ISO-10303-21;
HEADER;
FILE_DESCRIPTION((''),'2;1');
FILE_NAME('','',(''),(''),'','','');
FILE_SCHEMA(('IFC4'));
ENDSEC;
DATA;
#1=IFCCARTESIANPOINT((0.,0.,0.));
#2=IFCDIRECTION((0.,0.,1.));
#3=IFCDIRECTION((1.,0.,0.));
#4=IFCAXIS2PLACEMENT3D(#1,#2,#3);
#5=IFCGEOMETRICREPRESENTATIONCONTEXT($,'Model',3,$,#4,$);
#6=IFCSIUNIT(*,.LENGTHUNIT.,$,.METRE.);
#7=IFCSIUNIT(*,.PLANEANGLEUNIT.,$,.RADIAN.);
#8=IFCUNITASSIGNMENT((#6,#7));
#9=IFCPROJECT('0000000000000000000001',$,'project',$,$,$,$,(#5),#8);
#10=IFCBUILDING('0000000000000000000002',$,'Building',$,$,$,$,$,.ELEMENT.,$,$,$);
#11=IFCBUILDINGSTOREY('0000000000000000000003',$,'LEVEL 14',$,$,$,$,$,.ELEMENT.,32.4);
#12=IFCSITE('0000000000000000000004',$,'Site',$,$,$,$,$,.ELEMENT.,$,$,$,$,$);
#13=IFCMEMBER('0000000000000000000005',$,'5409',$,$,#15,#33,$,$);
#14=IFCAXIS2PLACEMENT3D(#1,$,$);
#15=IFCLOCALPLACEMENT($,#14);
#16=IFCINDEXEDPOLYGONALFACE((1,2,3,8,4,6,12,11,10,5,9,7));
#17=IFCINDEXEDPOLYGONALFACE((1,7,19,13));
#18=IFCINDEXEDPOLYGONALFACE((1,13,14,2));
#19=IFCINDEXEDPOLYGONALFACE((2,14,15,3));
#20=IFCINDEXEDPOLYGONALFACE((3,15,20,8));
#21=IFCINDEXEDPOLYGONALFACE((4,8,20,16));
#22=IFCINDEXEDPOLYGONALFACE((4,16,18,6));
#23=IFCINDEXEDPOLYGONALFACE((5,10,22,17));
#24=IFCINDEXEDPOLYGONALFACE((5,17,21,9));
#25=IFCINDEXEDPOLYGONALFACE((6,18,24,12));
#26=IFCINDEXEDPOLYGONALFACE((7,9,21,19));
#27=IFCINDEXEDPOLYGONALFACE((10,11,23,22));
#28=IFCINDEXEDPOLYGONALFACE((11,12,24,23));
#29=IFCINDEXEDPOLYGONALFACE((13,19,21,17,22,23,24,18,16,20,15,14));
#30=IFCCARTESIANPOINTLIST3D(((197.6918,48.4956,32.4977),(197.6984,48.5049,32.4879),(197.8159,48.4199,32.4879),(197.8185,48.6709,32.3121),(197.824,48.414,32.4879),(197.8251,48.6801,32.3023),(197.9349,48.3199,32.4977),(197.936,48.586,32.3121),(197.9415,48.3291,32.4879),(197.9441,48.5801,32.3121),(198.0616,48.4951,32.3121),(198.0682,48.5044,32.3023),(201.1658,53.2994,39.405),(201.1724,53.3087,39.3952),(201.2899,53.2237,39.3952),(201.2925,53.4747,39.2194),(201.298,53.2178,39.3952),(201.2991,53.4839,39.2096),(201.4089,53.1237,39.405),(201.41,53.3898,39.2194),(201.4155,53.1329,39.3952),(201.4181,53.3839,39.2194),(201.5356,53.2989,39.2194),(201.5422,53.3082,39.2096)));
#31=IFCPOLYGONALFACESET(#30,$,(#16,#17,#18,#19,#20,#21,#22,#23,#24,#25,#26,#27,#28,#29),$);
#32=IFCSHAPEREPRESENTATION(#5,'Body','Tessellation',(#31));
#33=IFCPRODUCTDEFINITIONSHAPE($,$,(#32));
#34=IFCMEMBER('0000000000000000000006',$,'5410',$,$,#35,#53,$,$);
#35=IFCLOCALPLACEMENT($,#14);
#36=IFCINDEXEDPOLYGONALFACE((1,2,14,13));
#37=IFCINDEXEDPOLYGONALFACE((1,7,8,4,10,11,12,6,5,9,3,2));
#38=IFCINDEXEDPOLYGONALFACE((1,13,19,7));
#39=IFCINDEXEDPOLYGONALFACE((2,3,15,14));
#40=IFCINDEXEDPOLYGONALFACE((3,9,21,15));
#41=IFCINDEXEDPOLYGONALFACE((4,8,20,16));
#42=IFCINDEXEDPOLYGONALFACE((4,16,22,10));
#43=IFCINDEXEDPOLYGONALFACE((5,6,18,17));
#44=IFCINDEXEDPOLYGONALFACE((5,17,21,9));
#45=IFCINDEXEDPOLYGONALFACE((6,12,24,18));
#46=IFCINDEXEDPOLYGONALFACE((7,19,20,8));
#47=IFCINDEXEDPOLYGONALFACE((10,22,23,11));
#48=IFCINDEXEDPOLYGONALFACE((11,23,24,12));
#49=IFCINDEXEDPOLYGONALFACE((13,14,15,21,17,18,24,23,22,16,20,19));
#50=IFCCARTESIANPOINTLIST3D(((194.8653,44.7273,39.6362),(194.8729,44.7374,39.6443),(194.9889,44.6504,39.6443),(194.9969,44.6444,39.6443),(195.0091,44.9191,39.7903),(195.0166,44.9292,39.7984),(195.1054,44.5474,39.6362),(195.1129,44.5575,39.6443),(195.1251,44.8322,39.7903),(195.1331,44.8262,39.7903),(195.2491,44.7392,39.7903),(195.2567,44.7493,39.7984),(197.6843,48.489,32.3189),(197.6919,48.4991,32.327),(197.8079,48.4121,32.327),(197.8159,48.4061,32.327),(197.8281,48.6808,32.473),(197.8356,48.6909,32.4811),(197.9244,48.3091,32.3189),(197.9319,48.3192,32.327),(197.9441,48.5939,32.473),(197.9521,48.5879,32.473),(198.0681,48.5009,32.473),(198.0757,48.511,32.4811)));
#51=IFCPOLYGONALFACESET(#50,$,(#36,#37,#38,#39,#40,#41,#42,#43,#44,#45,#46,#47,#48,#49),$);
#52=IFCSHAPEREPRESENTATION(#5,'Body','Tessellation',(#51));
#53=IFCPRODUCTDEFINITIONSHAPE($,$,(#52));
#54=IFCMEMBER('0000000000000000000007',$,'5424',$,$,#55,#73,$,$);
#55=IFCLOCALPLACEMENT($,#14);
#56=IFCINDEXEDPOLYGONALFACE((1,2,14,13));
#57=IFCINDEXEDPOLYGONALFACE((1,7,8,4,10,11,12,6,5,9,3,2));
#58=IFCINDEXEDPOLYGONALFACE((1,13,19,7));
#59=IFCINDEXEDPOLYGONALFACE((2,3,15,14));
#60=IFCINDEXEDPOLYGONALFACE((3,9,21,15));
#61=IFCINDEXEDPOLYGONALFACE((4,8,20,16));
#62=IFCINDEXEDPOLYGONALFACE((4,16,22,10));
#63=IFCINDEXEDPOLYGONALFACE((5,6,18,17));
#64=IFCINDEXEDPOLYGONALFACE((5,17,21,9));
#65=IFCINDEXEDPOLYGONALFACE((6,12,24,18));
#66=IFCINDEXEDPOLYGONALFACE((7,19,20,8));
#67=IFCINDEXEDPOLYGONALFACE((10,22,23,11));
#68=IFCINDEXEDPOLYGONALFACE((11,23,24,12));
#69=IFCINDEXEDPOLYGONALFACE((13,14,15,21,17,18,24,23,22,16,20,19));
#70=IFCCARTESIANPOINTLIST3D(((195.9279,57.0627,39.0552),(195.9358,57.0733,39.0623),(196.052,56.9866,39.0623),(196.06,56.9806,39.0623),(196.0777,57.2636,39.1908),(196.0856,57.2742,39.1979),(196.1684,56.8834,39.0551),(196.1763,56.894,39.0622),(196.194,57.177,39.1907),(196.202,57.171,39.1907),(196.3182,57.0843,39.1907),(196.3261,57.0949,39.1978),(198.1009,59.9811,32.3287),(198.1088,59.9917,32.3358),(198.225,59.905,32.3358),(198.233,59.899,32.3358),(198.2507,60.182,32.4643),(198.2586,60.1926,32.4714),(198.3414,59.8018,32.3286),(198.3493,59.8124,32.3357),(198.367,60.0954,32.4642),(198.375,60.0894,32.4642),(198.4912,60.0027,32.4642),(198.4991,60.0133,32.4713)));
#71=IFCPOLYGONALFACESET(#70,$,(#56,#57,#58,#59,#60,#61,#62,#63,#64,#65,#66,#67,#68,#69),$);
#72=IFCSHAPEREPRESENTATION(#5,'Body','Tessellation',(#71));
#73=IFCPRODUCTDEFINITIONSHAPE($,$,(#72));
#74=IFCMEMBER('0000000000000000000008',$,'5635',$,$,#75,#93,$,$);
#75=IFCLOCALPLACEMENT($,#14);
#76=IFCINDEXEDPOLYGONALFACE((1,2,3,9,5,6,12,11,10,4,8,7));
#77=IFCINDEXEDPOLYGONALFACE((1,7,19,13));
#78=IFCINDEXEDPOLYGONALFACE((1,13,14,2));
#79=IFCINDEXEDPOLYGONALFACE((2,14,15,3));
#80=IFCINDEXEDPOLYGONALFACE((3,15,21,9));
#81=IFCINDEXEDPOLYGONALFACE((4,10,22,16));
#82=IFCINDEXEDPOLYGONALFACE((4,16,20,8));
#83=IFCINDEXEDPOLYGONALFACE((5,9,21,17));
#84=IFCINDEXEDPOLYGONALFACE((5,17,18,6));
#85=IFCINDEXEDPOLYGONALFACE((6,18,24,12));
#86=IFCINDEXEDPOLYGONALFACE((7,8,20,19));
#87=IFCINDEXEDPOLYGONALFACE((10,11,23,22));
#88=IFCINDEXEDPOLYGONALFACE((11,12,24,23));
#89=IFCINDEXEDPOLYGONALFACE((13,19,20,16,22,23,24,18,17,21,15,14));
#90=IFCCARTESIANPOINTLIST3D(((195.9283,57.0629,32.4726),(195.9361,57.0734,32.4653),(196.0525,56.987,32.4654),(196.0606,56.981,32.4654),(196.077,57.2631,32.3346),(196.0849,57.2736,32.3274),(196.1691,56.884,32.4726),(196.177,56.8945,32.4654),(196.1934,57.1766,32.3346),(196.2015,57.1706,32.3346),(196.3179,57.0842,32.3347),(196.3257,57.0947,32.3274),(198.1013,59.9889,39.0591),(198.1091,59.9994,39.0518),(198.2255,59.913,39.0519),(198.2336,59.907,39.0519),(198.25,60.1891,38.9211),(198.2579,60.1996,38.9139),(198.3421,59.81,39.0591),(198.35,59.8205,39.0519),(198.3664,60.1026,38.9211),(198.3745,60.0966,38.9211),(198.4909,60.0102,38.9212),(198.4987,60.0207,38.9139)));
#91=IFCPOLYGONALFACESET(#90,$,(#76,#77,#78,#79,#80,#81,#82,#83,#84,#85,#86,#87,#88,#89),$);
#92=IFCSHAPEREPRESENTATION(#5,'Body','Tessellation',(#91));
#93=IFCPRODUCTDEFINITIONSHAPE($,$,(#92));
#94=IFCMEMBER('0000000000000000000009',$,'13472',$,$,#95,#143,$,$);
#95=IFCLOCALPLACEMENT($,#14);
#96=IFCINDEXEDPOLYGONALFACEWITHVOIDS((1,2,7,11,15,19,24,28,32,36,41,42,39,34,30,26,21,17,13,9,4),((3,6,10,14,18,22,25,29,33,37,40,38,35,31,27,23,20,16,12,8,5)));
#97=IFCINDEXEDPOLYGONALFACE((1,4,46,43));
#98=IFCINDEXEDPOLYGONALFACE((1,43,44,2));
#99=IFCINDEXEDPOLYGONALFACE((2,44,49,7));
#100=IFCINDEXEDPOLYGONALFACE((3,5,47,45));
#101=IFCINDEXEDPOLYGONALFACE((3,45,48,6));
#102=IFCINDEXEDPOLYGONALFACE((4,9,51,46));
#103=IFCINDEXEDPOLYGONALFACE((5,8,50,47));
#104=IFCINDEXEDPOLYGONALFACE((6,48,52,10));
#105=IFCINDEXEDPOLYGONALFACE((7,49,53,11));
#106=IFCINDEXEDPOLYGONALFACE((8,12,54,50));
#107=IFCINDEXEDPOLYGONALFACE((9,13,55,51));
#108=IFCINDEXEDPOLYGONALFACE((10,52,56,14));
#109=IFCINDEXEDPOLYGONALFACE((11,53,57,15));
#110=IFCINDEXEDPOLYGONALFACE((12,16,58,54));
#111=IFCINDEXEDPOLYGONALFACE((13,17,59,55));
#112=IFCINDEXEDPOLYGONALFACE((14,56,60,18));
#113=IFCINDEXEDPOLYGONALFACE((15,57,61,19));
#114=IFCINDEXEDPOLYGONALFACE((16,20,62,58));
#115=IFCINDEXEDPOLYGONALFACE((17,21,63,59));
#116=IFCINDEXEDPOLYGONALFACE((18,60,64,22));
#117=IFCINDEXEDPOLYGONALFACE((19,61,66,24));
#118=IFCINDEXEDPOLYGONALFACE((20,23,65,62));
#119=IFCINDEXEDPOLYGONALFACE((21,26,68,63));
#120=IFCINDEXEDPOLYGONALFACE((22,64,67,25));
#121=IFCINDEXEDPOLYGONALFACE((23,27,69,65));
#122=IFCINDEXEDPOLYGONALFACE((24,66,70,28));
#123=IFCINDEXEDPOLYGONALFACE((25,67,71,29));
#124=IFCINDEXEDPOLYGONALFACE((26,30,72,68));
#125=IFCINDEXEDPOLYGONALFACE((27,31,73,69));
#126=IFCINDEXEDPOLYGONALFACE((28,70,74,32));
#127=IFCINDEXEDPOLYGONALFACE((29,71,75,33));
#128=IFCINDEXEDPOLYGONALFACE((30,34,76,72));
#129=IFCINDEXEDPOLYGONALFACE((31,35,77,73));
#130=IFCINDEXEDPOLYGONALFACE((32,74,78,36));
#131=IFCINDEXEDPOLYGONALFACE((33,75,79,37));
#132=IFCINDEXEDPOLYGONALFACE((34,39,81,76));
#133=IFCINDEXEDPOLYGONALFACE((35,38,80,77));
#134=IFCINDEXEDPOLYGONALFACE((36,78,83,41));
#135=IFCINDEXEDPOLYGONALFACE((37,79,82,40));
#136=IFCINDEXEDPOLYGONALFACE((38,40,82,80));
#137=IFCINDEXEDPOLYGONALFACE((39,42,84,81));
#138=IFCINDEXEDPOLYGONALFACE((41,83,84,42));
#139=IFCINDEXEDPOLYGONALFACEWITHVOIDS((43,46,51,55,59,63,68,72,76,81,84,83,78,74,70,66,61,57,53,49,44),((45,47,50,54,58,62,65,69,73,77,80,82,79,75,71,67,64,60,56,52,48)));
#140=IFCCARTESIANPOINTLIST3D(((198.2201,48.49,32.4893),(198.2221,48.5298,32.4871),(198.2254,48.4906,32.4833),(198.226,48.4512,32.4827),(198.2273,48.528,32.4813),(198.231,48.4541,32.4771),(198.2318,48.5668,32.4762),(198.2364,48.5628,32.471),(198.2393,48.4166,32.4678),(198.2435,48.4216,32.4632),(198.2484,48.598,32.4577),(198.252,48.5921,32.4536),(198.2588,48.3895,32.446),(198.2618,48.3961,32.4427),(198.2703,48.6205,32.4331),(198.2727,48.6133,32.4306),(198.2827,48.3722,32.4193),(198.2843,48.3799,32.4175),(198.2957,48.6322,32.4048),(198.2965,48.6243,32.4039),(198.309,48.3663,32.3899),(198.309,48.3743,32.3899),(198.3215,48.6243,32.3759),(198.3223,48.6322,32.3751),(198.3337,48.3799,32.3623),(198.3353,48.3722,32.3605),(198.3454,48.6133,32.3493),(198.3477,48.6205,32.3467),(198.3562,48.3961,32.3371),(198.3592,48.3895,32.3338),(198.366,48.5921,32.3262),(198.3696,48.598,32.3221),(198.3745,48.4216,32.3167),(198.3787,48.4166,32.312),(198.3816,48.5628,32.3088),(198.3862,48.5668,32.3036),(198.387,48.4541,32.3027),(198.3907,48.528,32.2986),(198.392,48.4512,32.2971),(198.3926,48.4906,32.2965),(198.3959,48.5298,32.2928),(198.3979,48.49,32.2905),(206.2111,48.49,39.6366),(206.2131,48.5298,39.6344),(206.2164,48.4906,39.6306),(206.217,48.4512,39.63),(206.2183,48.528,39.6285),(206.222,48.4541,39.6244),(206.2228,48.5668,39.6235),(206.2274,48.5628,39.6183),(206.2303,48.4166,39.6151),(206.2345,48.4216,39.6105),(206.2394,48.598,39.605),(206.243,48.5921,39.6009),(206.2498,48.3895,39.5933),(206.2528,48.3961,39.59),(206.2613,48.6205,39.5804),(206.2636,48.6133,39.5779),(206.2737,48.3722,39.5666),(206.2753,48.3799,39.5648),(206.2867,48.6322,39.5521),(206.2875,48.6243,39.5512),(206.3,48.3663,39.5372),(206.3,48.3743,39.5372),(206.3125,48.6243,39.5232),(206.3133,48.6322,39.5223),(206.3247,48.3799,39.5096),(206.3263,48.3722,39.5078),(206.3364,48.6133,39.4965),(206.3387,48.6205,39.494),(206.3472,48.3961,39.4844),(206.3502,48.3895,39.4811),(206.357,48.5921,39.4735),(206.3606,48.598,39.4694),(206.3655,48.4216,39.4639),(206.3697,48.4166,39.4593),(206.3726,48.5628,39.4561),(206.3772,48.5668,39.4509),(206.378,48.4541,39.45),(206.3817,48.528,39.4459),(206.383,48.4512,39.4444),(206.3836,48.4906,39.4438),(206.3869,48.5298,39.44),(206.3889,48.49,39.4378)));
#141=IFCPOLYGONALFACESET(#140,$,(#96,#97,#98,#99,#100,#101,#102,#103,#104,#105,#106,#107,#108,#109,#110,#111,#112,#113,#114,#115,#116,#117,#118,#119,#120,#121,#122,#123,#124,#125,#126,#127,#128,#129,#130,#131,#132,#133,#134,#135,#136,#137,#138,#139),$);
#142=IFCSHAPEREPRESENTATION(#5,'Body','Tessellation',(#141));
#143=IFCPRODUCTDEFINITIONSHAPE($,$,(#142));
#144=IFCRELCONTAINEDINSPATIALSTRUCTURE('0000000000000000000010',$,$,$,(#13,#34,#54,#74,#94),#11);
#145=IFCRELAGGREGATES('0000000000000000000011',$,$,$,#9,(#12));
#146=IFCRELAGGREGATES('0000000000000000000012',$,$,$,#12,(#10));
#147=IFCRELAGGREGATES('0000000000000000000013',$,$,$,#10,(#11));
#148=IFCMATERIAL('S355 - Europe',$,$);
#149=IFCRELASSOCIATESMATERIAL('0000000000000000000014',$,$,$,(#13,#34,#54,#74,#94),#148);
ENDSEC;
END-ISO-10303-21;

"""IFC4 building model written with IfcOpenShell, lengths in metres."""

from ifc_helpers import new_model, si_unit, frame, origin_with_axes, origin_2d_with_axis, place, context, project, spatial, hollow_circle, i_section, extrude, material, material_profile, profile_set, profile_usage, element, save


model = new_model("IFC4")

# Units and contexts
model_context = context("Model", 3, world=origin_with_axes())
ifc_project = project(units=[si_unit("LENGTHUNIT", "METRE"), si_unit("PLANEANGLEUNIT", "RADIAN")], contexts=[model_context])

# Site, building, storey
site = spatial("IfcSite", under=ifc_project, Name="Site", CompositionType="ELEMENT")
building = spatial("IfcBuilding", under=site, Name="Building", CompositionType="ELEMENT")
storey = spatial("IfcBuildingStorey", under=building, Name="LEVEL 14", CompositionType="ELEMENT", Elevation=32.4)

# Shared definitions
ifc_material = material(Name="S355 - Europe")

# Members
ifc_material_profile_1 = material_profile(ifc_material, i_section(OverallWidth=0.3, OverallDepth=0.3, WebThickness=0.01, FlangeThickness=0.015, at=origin_2d_with_axis()))
ifc_profile_set_1 = profile_set([ifc_material_profile_1])
ifc_profile_usage_1 = profile_usage(ifc_profile_set_1, cardinal=10)
member_1_placement = place(None, frame((197.88, 48.5, 32.4), z_axis=(0.381652, 0.527744, 0.758833), x_axis=(-0.810441, 0.585821, 0.0)))
element("IfcMember", 1, at=member_1_placement, inside=storey, material=ifc_profile_usage_1, Name="5409", context=model_context, shape_type="SweptSolid", body=[
    extrude(i_section(OverallWidth=0.3, OverallDepth=0.3, WebThickness=0.01, FlangeThickness=0.015, at=origin_2d_with_axis()), origin_with_axes(), (0.0, 0.0, 1.0), 9.1025),
])
ifc_material_profile_2 = material_profile(ifc_material, i_section(OverallWidth=0.3, OverallDepth=0.3, WebThickness=0.01, FlangeThickness=0.015, at=origin_2d_with_axis()))
ifc_profile_set_2 = profile_set([ifc_material_profile_2])
ifc_profile_usage_2 = profile_usage(ifc_profile_set_2, cardinal=10)
member_2_placement = place(None, frame((195.061, 44.7383, 39.7173), z_axis=(0.32413, 0.432522, -0.841347), x_axis=(-0.800232, 0.59969, 0.0)))
element("IfcMember", 2, at=member_2_placement, inside=storey, material=ifc_profile_usage_2, Name="5410", context=model_context, shape_type="SweptSolid", body=[
    extrude(i_section(OverallWidth=0.3, OverallDepth=0.3, WebThickness=0.01, FlangeThickness=0.015, at=origin_2d_with_axis()), origin_with_axes(), (0.0, 0.0, 1.0), 8.6971),
])
ifc_material_profile_3 = material_profile(ifc_material, i_section(OverallWidth=0.3, OverallDepth=0.3, WebThickness=0.01, FlangeThickness=0.015, at=origin_2d_with_axis()))
ifc_profile_set_3 = profile_set([ifc_material_profile_3])
ifc_profile_usage_3 = profile_usage(ifc_profile_set_3, cardinal=10)
member_3_placement = place(None, frame((196.127, 57.0788, 39.1265), z_axis=(0.284144, 0.381613, -0.879564), x_axis=(-0.801686, 0.597746, 0.0)))
element("IfcMember", 3, at=member_3_placement, inside=storey, material=ifc_profile_usage_3, Name="5424", context=model_context, shape_type="SweptSolid", body=[
    extrude(i_section(OverallWidth=0.3, OverallDepth=0.3, WebThickness=0.01, FlangeThickness=0.015, at=origin_2d_with_axis()), origin_with_axes(), (0.0, 0.0, 1.0), 7.6475),
])
ifc_material_profile_4 = material_profile(ifc_material, i_section(OverallWidth=0.3, OverallDepth=0.3, WebThickness=0.01, FlangeThickness=0.015, at=origin_2d_with_axis()))
ifc_profile_set_4 = profile_set([ifc_material_profile_4])
ifc_profile_usage_4 = profile_usage(ifc_profile_set_4, cardinal=10)
member_4_placement = place(None, frame((196.127, 57.0788, 32.4), z_axis=(0.288669, 0.388701, 0.874975), x_axis=(-0.802692, 0.596394, 0.0)))
element("IfcMember", 4, at=member_4_placement, inside=storey, material=ifc_profile_usage_4, Name="5635", context=model_context, shape_type="SweptSolid", body=[
    extrude(i_section(OverallWidth=0.3, OverallDepth=0.3, WebThickness=0.01, FlangeThickness=0.015, at=origin_2d_with_axis()), origin_with_axes(), (0.0, 0.0, 1.0), 7.5276),
])
ifc_material_profile_5 = material_profile(ifc_material, hollow_circle(Radius=0.1337, WallThickness=0.008, at=origin_2d_with_axis()))
ifc_profile_set_5 = profile_set([ifc_material_profile_5])
ifc_profile_usage_5 = profile_usage(ifc_profile_set_5, cardinal=10)
member_5_placement = place(None, frame((206.3, 48.5, 39.5372), z_axis=(-0.745359, 0.0, -0.666663), x_axis=(0.0, -1.0, 0.0)))
element("IfcMember", 5, at=member_5_placement, inside=storey, material=ifc_profile_usage_5, Name="13472", context=model_context, shape_type="SweptSolid", body=[
    extrude(hollow_circle(Radius=0.1337, WallThickness=0.008, at=origin_2d_with_axis()), origin_with_axes(), (0.0, 0.0, 1.0), 10.721),
])

save(model, "model.ifc")
